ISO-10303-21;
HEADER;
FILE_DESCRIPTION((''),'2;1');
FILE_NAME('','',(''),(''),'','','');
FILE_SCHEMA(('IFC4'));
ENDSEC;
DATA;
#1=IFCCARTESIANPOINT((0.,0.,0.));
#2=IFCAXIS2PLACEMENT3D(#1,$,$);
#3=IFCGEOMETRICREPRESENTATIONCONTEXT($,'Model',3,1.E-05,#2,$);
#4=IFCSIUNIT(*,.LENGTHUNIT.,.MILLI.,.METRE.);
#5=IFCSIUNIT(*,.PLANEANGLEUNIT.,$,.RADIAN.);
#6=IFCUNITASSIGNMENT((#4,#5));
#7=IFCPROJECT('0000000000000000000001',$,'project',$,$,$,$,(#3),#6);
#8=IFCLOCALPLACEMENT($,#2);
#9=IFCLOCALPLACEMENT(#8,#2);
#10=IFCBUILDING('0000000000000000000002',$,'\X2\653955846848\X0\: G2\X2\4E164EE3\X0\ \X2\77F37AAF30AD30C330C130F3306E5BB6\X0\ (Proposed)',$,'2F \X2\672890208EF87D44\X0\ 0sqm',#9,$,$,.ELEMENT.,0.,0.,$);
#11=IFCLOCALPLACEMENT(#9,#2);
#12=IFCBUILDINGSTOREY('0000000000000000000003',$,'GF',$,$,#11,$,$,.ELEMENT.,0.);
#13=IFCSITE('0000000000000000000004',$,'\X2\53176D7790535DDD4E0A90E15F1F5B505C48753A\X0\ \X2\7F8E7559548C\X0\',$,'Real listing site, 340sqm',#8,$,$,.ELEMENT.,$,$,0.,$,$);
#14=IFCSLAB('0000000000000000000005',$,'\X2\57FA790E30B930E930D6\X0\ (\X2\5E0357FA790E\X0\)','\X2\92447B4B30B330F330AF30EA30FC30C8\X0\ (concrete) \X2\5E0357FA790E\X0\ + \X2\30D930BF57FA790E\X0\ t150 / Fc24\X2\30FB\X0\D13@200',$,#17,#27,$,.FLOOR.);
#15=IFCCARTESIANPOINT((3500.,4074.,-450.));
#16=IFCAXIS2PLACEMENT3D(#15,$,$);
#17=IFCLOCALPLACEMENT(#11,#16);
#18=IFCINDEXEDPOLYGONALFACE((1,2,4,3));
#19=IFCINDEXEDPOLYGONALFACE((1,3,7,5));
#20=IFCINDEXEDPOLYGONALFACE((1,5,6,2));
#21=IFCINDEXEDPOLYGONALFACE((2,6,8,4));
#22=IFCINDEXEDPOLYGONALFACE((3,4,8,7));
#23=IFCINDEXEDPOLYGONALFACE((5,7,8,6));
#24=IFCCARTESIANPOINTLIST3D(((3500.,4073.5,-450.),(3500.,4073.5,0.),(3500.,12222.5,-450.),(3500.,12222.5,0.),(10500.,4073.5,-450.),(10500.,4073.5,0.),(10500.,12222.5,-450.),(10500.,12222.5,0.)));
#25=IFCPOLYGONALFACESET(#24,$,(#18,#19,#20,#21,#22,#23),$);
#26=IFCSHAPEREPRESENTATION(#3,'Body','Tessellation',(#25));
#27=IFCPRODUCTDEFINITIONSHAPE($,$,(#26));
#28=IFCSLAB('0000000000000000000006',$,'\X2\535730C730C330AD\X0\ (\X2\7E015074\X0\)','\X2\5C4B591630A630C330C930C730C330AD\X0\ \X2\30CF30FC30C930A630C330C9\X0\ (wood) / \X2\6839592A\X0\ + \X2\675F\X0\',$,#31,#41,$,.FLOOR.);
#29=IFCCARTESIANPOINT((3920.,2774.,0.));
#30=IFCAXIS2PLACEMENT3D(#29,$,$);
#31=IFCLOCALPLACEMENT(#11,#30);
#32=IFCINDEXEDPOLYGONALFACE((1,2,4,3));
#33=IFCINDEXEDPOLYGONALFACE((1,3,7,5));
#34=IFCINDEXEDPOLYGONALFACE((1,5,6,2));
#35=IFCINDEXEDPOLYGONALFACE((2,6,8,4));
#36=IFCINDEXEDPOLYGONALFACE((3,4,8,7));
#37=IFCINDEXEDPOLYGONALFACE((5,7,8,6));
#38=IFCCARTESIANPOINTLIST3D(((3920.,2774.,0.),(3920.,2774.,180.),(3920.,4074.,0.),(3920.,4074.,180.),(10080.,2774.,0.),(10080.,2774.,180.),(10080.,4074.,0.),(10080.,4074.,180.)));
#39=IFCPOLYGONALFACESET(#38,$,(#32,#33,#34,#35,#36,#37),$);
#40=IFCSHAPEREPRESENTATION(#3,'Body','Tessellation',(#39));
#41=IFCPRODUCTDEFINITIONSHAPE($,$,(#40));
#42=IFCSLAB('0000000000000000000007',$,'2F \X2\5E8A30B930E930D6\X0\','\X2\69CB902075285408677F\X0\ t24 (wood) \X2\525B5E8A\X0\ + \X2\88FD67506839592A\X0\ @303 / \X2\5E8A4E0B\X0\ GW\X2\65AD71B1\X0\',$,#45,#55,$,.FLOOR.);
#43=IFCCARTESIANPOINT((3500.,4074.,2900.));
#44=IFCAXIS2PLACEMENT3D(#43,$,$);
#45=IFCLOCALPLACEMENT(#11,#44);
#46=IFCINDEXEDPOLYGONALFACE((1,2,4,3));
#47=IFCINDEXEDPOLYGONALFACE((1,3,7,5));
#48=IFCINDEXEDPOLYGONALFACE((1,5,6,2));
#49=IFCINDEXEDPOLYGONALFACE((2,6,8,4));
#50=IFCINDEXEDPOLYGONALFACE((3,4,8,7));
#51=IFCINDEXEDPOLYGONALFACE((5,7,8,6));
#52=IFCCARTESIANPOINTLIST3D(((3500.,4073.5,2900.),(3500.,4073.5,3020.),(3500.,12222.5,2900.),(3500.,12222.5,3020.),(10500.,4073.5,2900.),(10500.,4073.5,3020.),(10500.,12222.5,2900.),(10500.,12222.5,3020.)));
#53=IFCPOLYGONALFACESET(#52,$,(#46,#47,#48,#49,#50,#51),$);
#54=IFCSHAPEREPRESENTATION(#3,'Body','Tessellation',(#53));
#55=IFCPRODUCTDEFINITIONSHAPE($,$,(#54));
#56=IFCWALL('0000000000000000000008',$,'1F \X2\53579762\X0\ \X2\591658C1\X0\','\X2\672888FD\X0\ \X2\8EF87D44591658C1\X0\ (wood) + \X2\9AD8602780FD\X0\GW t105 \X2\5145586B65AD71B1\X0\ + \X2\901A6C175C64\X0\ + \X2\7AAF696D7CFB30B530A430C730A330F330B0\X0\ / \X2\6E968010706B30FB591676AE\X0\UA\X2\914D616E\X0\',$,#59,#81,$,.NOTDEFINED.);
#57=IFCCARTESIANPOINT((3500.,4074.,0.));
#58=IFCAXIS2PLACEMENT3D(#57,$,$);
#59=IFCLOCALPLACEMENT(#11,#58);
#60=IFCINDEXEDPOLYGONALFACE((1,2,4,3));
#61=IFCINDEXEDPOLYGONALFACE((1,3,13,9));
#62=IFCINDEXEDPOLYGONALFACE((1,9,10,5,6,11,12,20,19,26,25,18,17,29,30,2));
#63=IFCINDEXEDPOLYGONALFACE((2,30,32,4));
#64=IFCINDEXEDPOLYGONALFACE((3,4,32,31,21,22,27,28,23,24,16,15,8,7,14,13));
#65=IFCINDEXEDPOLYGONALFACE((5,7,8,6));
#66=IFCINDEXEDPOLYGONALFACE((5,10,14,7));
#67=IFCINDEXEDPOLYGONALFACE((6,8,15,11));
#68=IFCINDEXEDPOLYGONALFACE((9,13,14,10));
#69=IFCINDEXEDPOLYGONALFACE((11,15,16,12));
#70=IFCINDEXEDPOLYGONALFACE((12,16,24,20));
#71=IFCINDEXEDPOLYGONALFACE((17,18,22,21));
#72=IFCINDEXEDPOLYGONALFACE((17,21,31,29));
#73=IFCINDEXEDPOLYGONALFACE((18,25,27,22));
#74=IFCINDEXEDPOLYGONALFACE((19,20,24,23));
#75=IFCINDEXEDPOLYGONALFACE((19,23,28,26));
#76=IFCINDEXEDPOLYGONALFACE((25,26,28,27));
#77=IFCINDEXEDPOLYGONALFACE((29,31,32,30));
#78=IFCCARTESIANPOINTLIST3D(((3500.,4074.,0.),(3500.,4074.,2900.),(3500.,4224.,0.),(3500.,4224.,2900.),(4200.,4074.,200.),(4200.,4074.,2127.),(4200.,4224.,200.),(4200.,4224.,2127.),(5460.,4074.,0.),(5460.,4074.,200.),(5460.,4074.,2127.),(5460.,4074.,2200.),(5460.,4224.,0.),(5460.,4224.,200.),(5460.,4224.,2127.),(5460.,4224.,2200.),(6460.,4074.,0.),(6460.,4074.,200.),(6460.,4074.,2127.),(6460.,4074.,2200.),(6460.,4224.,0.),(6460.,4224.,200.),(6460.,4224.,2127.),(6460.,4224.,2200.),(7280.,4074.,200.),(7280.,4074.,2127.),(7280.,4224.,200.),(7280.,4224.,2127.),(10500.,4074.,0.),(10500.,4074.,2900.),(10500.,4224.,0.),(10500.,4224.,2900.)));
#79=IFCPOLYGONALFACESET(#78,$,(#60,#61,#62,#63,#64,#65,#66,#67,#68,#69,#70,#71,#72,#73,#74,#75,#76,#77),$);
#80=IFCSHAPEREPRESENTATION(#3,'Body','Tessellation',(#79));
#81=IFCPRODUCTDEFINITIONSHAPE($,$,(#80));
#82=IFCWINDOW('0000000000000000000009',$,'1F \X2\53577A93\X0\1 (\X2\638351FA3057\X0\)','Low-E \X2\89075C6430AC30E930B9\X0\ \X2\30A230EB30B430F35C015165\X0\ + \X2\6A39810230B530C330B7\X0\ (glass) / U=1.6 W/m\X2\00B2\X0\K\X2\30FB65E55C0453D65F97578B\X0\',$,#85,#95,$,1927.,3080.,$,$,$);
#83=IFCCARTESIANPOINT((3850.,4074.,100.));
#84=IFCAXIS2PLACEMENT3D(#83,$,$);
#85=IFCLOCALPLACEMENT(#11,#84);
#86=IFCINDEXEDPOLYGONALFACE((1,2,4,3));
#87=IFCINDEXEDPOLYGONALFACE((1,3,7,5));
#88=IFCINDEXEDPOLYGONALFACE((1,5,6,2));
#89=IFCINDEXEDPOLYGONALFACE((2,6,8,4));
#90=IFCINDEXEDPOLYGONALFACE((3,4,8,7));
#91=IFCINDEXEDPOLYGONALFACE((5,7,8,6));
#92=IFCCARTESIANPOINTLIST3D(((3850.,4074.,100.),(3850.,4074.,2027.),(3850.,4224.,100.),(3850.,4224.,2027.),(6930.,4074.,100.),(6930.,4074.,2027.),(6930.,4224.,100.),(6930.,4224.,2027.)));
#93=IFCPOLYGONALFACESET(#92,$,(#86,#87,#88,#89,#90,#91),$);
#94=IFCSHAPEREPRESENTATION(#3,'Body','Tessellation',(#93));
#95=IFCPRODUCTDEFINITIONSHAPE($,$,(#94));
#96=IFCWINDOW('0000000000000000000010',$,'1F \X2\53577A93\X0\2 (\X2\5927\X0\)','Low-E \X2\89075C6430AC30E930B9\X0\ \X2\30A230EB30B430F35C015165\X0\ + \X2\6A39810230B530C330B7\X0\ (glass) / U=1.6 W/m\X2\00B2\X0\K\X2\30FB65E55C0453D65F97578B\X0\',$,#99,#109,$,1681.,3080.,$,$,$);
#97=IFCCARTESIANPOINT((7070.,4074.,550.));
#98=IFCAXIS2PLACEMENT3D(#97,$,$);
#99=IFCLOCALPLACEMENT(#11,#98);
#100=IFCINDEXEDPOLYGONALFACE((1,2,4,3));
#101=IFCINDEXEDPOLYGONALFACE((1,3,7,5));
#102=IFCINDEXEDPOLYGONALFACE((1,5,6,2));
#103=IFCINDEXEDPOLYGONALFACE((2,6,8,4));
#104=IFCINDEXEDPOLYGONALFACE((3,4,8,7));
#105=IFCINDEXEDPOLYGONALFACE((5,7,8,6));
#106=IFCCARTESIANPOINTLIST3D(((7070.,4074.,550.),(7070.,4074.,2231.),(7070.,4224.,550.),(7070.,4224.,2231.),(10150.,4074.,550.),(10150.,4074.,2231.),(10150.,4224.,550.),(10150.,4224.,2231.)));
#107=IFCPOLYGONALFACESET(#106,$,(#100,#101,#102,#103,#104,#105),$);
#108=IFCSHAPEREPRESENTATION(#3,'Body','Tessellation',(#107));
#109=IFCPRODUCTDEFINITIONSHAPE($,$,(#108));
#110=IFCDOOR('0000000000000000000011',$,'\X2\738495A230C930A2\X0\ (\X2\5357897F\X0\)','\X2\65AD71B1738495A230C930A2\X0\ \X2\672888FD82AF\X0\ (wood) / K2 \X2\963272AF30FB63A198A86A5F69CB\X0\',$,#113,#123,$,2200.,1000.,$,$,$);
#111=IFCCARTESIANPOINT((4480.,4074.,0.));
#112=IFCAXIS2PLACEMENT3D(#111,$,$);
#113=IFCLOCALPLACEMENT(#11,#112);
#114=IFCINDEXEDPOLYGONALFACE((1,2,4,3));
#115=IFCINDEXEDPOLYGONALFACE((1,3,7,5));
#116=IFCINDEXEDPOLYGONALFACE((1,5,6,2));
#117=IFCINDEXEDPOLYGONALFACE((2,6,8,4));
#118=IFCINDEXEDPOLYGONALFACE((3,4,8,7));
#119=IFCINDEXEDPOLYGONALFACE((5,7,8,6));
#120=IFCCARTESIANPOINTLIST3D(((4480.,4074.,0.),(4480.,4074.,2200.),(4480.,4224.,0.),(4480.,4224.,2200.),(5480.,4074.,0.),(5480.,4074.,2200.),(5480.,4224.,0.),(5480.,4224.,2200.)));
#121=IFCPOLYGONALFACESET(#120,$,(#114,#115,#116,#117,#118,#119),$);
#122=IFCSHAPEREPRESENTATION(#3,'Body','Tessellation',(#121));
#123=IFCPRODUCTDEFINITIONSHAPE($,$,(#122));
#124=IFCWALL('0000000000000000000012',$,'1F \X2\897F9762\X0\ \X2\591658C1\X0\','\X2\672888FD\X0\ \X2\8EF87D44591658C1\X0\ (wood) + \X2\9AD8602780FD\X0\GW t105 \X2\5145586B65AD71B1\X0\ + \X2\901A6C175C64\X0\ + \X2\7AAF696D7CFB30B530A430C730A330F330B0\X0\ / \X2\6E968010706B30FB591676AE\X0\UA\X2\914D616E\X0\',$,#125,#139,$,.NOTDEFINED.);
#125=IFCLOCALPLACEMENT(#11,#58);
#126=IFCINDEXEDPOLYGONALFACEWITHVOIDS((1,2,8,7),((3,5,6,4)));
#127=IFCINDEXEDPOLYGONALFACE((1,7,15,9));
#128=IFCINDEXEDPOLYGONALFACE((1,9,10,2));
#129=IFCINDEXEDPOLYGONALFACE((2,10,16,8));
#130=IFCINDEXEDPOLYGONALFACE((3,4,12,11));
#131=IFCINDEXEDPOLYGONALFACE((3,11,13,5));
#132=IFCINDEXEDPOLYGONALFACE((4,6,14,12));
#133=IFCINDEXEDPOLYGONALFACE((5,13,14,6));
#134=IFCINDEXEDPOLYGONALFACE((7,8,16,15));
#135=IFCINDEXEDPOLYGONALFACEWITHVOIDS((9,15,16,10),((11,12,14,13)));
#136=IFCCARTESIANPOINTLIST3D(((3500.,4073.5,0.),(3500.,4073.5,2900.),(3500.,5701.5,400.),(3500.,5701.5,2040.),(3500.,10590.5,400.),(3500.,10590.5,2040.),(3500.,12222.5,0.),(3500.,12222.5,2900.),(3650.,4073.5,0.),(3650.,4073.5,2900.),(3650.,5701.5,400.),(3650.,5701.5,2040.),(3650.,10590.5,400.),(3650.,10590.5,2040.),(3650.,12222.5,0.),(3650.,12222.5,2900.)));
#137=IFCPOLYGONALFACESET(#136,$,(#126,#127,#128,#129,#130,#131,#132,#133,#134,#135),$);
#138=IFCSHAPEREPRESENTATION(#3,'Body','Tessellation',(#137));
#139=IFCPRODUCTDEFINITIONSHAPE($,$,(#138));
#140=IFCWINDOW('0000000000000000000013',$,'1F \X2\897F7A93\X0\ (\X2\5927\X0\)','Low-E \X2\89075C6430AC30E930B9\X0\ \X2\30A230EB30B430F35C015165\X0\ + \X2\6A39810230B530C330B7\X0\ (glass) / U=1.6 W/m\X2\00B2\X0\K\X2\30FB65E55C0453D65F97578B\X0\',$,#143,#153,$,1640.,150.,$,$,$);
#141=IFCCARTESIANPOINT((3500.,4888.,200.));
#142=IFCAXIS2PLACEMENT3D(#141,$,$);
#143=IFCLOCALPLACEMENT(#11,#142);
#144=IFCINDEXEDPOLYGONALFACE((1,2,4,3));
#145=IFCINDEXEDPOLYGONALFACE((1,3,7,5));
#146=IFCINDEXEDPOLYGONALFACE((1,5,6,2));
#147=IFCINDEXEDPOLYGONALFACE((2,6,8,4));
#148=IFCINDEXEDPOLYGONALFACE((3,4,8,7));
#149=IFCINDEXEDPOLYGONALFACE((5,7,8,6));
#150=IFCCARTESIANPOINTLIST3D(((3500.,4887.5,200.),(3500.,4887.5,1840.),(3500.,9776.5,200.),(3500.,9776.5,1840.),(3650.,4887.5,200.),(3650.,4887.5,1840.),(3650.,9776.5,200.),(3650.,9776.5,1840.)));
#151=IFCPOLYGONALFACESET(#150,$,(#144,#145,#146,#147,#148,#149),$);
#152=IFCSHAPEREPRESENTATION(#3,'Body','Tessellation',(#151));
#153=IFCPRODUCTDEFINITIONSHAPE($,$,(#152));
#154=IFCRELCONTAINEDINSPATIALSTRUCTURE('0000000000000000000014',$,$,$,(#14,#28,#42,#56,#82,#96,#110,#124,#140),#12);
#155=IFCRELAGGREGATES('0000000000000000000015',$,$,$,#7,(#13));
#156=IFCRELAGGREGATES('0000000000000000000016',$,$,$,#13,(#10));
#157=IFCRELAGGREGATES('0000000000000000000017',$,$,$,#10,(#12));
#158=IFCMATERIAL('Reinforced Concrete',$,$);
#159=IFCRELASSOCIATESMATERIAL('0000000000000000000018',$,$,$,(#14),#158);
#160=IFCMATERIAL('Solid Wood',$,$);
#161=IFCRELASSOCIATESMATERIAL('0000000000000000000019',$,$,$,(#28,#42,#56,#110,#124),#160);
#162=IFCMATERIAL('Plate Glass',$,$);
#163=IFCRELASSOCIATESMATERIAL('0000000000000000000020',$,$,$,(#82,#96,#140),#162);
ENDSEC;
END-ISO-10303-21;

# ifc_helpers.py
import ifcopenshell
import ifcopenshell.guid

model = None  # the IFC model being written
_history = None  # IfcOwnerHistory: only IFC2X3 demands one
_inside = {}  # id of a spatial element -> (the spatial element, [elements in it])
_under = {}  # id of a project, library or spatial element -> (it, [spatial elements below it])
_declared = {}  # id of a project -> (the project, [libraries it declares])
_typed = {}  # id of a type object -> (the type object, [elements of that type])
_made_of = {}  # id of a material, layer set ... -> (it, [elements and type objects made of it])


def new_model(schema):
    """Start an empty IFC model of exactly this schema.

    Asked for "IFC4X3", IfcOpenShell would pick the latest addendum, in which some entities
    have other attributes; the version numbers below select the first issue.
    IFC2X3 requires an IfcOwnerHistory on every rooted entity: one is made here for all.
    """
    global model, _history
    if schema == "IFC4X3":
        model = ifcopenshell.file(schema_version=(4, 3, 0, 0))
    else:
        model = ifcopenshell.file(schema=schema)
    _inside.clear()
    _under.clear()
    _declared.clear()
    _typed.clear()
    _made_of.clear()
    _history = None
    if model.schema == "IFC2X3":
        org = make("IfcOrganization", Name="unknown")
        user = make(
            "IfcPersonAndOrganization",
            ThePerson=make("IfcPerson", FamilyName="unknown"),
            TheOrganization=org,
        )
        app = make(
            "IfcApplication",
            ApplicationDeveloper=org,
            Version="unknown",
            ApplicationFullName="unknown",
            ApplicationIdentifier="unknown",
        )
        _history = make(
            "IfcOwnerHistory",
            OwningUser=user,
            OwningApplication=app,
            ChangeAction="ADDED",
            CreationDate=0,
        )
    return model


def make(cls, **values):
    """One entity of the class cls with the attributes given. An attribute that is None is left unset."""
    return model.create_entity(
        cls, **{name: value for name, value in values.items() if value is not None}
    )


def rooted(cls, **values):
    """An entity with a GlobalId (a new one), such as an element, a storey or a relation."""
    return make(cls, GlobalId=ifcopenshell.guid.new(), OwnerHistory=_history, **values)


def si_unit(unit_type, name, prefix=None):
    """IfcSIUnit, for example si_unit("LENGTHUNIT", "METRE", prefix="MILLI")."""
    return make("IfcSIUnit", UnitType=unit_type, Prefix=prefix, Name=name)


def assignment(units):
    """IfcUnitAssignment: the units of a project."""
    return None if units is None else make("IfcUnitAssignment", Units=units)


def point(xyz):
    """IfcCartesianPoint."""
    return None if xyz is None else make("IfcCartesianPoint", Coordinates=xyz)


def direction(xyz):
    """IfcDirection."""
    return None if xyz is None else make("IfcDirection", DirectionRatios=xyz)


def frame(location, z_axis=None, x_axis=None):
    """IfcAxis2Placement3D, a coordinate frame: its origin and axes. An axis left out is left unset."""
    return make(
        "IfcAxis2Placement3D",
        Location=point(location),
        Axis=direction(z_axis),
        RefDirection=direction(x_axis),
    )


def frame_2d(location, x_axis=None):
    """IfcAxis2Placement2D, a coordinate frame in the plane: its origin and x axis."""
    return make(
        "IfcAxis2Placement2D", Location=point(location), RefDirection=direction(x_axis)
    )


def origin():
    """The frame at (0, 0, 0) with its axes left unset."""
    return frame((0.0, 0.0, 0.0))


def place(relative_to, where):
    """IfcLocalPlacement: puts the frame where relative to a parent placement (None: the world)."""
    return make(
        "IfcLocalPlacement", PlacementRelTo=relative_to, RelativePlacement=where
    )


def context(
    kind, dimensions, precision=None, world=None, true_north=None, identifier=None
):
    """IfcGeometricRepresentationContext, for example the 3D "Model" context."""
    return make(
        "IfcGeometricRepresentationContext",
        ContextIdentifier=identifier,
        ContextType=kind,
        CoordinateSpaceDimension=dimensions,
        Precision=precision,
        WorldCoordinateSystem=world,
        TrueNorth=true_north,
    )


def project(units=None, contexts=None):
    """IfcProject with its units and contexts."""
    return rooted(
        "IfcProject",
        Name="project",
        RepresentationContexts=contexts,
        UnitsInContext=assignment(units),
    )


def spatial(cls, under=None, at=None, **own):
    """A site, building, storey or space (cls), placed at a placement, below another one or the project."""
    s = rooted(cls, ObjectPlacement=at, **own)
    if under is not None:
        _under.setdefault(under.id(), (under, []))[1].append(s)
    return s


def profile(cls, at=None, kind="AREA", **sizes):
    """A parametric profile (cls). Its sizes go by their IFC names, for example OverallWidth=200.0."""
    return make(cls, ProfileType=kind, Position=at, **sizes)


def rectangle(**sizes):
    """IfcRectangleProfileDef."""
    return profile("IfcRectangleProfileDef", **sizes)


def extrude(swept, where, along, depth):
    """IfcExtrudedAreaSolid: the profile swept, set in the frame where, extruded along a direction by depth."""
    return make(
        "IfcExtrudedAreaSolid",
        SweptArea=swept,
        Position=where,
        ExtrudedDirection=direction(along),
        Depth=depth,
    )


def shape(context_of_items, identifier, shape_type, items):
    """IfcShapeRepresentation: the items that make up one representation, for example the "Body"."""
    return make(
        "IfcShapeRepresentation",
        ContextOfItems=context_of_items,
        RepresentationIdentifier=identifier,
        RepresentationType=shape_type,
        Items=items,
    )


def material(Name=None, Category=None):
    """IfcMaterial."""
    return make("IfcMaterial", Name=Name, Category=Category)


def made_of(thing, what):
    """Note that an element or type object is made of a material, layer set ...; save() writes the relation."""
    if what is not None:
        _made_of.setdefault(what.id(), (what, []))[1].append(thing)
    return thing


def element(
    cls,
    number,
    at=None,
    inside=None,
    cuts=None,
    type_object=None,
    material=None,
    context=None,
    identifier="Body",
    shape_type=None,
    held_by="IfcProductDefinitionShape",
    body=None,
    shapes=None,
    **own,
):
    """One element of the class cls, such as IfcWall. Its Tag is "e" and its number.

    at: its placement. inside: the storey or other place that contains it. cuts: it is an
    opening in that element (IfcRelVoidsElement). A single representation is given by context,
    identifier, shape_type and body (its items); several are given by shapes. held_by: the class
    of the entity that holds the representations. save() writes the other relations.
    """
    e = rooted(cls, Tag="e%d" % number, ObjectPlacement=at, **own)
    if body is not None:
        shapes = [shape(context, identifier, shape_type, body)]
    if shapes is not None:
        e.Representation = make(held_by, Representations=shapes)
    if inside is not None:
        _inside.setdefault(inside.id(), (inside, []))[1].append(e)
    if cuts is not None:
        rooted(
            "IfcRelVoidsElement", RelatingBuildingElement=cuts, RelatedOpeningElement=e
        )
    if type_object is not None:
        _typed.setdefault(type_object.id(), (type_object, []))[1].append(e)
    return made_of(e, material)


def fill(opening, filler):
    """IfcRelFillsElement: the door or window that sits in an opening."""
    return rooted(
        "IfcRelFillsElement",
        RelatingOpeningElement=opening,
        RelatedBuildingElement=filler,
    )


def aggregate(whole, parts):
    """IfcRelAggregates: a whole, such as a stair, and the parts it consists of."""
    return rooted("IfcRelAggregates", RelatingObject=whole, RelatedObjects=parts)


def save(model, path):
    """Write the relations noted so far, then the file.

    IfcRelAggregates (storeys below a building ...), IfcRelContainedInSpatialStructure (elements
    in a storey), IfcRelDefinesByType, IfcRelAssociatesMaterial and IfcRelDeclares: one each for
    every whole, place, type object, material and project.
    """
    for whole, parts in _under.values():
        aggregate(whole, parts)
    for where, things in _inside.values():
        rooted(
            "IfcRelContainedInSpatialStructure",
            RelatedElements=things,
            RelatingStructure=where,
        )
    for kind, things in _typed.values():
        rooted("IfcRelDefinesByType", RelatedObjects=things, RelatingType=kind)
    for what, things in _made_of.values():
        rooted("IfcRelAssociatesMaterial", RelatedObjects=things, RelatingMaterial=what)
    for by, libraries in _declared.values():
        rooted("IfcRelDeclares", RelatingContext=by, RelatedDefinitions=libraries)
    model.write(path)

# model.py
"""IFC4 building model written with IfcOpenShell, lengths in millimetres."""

from ifc_helpers import new_model, si_unit, frame, frame_2d, origin, place, context, project, spatial, rectangle, extrude, material, element, fill, save


model = new_model("IFC4")

# Units and contexts
model_context = context("Model", 3, precision=1e-05, world=origin())
ifc_project = project(units=[si_unit("LENGTHUNIT", "METRE", prefix="MILLI"), si_unit("PLANEANGLEUNIT", "RADIAN")], contexts=[model_context])

# Site, building, storey
site_placement = place(None, origin())
site = spatial("IfcSite", under=ifc_project, at=site_placement, Name="北海道川上郡弟子屈町 美留和", ObjectType="Real listing site, 340sqm", CompositionType="ELEMENT", RefElevation=0.0)
building_placement = place(site_placement, origin())
building = spatial("IfcBuilding", under=site, at=building_placement, Name="改善案: G2世代 石窯キッチンの家 (Proposed)", ObjectType="2F 木造軸組 0sqm", CompositionType="ELEMENT", ElevationOfRefHeight=0.0, ElevationOfTerrain=0.0)
storey_placement = place(building_placement, origin())
storey = spatial("IfcBuildingStorey", under=building, at=storey_placement, Name="GF", CompositionType="ELEMENT", Elevation=0.0)

# Slabs
ifc_material_1 = material(Name="Reinforced Concrete")
slab_1_placement = place(storey_placement, frame((3500.0, 4074.0, -450.0)))
element("IfcSlab", 1, at=slab_1_placement, inside=storey, material=ifc_material_1, Name="基礎スラブ (布基礎)", Description="鉄筋コンクリート (concrete) 布基礎 + ベタ基礎 t150 / Fc24・D13@200", PredefinedType="FLOOR", context=model_context, shape_type="SweptSolid", body=[
    extrude(rectangle(XDim=7000.0, YDim=8149.0, at=frame_2d((3500.0, 4074.0))), frame((3500.0, 4074.0, -450.0)), (0.0, 0.0, 1.0), 450.0),
])
ifc_material_2 = material(Name="Solid Wood")
slab_2_placement = place(storey_placement, frame((3920.0, 2774.0, 0.0)))
element("IfcSlab", 2, at=slab_2_placement, inside=storey, material=ifc_material_2, Name="南デッキ (縁側)", Description="屋外ウッドデッキ ハードウッド (wood) / 根太 + 束", PredefinedType="FLOOR", context=model_context, shape_type="SweptSolid", body=[
    extrude(rectangle(XDim=6160.0, YDim=1300.0, at=frame_2d((3080.0, 650.0))), frame((3920.0, 2774.0, 0.0)), (0.0, 0.0, 1.0), 180.0),
])
slab_3_placement = place(storey_placement, frame((3500.0, 4074.0, 2900.0)))
element("IfcSlab", 3, at=slab_3_placement, inside=storey, material=ifc_material_2, Name="2F 床スラブ", Description="構造用合板 t24 (wood) 剛床 + 製材根太 @303 / 床下 GW断熱", PredefinedType="FLOOR", context=model_context, shape_type="SweptSolid", body=[
    extrude(rectangle(XDim=7000.0, YDim=8149.0, at=frame_2d((3500.0, 4074.0))), frame((3500.0, 4074.0, 2900.0)), (0.0, 0.0, 1.0), 120.0),
])

# Wall, openings, windows, door
wall_1_placement = place(storey_placement, frame((3500.0, 4074.0, 0.0)))
wall_1 = element("IfcWall", 4, at=wall_1_placement, inside=storey, material=ifc_material_2, Name="1F 南面 外壁", Description="木製 軸組外壁 (wood) + 高性能GW t105 充填断熱 + 通気層 + 窯業系サイディング / 準耐火・外皮UA配慮", PredefinedType="NOTDEFINED", context=model_context, shape_type="SweptSolid", body=[
    extrude(rectangle(XDim=7000.0, YDim=150.0, at=frame_2d((3500.0, 75.0))), frame((3500.0, 4074.0, 0.0)), (0.0, 0.0, 1.0), 2900.0),
])
opening_1_placement = place(storey_placement, frame((3850.0, 4074.0, 100.0)))
opening_1 = element("IfcOpeningElement", 5, at=opening_1_placement, cuts=wall_1, PredefinedType="NOTDEFINED", context=model_context, shape_type="SweptSolid", body=[
    extrude(rectangle(XDim=3080.0, YDim=150.0, at=frame_2d((1540.0, 75.0))), frame((3850.0, 4074.0, 100.0)), (0.0, 0.0, 1.0), 1927.0),
])
opening_2_placement = place(storey_placement, frame((7070.0, 4074.0, 550.0)))
opening_2 = element("IfcOpeningElement", 6, at=opening_2_placement, cuts=wall_1, PredefinedType="NOTDEFINED", context=model_context, shape_type="SweptSolid", body=[
    extrude(rectangle(XDim=3080.0, YDim=150.0, at=frame_2d((1540.0, 75.0))), frame((7070.0, 4074.0, 550.0)), (0.0, 0.0, 1.0), 1681.0),
])
opening_3_placement = place(storey_placement, frame((4480.0, 4074.0, 0.0)))
opening_3 = element("IfcOpeningElement", 7, at=opening_3_placement, cuts=wall_1, PredefinedType="NOTDEFINED", context=model_context, shape_type="SweptSolid", body=[
    extrude(rectangle(XDim=1000.0, YDim=150.0, at=frame_2d((500.0, 75.0))), frame((4480.0, 4074.0, 0.0)), (0.0, 0.0, 1.0), 2200.0),
])
ifc_material_3 = material(Name="Plate Glass")
window_1_placement = place(storey_placement, frame((3850.0, 4074.0, 100.0)))
window_1 = element("IfcWindow", 8, at=window_1_placement, inside=storey, material=ifc_material_3, Name="1F 南窓1 (掃出し)", Description="Low-E 複層ガラス アルゴン封入 + 樹脂サッシ (glass) / U=1.6 W/m²K・日射取得型", OverallHeight=1927.0, OverallWidth=3080.0, context=model_context, shape_type="SweptSolid", body=[
    extrude(rectangle(XDim=3080.0, YDim=150.0, at=frame_2d((1540.0, 75.0))), frame((3850.0, 4074.0, 100.0)), (0.0, 0.0, 1.0), 1927.0),
])
fill(opening_1, window_1)
window_2_placement = place(storey_placement, frame((7070.0, 4074.0, 550.0)))
window_2 = element("IfcWindow", 9, at=window_2_placement, inside=storey, material=ifc_material_3, Name="1F 南窓2 (大)", Description="Low-E 複層ガラス アルゴン封入 + 樹脂サッシ (glass) / U=1.6 W/m²K・日射取得型", OverallHeight=1681.0, OverallWidth=3080.0, context=model_context, shape_type="SweptSolid", body=[
    extrude(rectangle(XDim=3080.0, YDim=150.0, at=frame_2d((1540.0, 75.0))), frame((7070.0, 4074.0, 550.0)), (0.0, 0.0, 1.0), 1681.0),
])
fill(opening_2, window_2)
door_placement = place(storey_placement, frame((4480.0, 4074.0, 0.0)))
door = element("IfcDoor", 10, at=door_placement, inside=storey, material=ifc_material_2, Name="玄関ドア (南西)", Description="断熱玄関ドア 木製芯 (wood) / K2 防犯・採風機構", OverallHeight=2200.0, OverallWidth=1000.0, context=model_context, shape_type="SweptSolid", body=[
    extrude(rectangle(XDim=1000.0, YDim=150.0, at=frame_2d((500.0, 75.0))), frame((4480.0, 4074.0, 0.0)), (0.0, 0.0, 1.0), 2200.0),
])
fill(opening_3, door)

# Wall, opening, window
wall_2_placement = place(storey_placement, frame((3500.0, 4074.0, 0.0)))
wall_2 = element("IfcWall", 11, at=wall_2_placement, inside=storey, material=ifc_material_2, Name="1F 西面 外壁", Description="木製 軸組外壁 (wood) + 高性能GW t105 充填断熱 + 通気層 + 窯業系サイディング / 準耐火・外皮UA配慮", PredefinedType="NOTDEFINED", context=model_context, shape_type="SweptSolid", body=[
    extrude(rectangle(XDim=150.0, YDim=8149.0, at=frame_2d((75.0, 4074.0))), frame((3500.0, 4074.0, 0.0)), (0.0, 0.0, 1.0), 2900.0),
])
opening_4_placement = place(storey_placement, frame((3500.0, 4888.0, 200.0)))
opening_4 = element("IfcOpeningElement", 12, at=opening_4_placement, cuts=wall_2, PredefinedType="NOTDEFINED", context=model_context, shape_type="SweptSolid", body=[
    extrude(rectangle(XDim=150.0, YDim=4889.0, at=frame_2d((75.0, 2444.0))), frame((3500.0, 4888.0, 200.0)), (0.0, 0.0, 1.0), 1640.0),
])
window_3_placement = place(storey_placement, frame((3500.0, 4888.0, 200.0)))
window_3 = element("IfcWindow", 13, at=window_3_placement, inside=storey, material=ifc_material_3, Name="1F 西窓 (大)", Description="Low-E 複層ガラス アルゴン封入 + 樹脂サッシ (glass) / U=1.6 W/m²K・日射取得型", OverallHeight=1640.0, OverallWidth=150.0, context=model_context, shape_type="SweptSolid", body=[
    extrude(rectangle(XDim=150.0, YDim=4889.0, at=frame_2d((75.0, 2444.0))), frame((3500.0, 4888.0, 200.0)), (0.0, 0.0, 1.0), 1640.0),
])
fill(opening_4, window_3)

save(model, "model.ifc")
